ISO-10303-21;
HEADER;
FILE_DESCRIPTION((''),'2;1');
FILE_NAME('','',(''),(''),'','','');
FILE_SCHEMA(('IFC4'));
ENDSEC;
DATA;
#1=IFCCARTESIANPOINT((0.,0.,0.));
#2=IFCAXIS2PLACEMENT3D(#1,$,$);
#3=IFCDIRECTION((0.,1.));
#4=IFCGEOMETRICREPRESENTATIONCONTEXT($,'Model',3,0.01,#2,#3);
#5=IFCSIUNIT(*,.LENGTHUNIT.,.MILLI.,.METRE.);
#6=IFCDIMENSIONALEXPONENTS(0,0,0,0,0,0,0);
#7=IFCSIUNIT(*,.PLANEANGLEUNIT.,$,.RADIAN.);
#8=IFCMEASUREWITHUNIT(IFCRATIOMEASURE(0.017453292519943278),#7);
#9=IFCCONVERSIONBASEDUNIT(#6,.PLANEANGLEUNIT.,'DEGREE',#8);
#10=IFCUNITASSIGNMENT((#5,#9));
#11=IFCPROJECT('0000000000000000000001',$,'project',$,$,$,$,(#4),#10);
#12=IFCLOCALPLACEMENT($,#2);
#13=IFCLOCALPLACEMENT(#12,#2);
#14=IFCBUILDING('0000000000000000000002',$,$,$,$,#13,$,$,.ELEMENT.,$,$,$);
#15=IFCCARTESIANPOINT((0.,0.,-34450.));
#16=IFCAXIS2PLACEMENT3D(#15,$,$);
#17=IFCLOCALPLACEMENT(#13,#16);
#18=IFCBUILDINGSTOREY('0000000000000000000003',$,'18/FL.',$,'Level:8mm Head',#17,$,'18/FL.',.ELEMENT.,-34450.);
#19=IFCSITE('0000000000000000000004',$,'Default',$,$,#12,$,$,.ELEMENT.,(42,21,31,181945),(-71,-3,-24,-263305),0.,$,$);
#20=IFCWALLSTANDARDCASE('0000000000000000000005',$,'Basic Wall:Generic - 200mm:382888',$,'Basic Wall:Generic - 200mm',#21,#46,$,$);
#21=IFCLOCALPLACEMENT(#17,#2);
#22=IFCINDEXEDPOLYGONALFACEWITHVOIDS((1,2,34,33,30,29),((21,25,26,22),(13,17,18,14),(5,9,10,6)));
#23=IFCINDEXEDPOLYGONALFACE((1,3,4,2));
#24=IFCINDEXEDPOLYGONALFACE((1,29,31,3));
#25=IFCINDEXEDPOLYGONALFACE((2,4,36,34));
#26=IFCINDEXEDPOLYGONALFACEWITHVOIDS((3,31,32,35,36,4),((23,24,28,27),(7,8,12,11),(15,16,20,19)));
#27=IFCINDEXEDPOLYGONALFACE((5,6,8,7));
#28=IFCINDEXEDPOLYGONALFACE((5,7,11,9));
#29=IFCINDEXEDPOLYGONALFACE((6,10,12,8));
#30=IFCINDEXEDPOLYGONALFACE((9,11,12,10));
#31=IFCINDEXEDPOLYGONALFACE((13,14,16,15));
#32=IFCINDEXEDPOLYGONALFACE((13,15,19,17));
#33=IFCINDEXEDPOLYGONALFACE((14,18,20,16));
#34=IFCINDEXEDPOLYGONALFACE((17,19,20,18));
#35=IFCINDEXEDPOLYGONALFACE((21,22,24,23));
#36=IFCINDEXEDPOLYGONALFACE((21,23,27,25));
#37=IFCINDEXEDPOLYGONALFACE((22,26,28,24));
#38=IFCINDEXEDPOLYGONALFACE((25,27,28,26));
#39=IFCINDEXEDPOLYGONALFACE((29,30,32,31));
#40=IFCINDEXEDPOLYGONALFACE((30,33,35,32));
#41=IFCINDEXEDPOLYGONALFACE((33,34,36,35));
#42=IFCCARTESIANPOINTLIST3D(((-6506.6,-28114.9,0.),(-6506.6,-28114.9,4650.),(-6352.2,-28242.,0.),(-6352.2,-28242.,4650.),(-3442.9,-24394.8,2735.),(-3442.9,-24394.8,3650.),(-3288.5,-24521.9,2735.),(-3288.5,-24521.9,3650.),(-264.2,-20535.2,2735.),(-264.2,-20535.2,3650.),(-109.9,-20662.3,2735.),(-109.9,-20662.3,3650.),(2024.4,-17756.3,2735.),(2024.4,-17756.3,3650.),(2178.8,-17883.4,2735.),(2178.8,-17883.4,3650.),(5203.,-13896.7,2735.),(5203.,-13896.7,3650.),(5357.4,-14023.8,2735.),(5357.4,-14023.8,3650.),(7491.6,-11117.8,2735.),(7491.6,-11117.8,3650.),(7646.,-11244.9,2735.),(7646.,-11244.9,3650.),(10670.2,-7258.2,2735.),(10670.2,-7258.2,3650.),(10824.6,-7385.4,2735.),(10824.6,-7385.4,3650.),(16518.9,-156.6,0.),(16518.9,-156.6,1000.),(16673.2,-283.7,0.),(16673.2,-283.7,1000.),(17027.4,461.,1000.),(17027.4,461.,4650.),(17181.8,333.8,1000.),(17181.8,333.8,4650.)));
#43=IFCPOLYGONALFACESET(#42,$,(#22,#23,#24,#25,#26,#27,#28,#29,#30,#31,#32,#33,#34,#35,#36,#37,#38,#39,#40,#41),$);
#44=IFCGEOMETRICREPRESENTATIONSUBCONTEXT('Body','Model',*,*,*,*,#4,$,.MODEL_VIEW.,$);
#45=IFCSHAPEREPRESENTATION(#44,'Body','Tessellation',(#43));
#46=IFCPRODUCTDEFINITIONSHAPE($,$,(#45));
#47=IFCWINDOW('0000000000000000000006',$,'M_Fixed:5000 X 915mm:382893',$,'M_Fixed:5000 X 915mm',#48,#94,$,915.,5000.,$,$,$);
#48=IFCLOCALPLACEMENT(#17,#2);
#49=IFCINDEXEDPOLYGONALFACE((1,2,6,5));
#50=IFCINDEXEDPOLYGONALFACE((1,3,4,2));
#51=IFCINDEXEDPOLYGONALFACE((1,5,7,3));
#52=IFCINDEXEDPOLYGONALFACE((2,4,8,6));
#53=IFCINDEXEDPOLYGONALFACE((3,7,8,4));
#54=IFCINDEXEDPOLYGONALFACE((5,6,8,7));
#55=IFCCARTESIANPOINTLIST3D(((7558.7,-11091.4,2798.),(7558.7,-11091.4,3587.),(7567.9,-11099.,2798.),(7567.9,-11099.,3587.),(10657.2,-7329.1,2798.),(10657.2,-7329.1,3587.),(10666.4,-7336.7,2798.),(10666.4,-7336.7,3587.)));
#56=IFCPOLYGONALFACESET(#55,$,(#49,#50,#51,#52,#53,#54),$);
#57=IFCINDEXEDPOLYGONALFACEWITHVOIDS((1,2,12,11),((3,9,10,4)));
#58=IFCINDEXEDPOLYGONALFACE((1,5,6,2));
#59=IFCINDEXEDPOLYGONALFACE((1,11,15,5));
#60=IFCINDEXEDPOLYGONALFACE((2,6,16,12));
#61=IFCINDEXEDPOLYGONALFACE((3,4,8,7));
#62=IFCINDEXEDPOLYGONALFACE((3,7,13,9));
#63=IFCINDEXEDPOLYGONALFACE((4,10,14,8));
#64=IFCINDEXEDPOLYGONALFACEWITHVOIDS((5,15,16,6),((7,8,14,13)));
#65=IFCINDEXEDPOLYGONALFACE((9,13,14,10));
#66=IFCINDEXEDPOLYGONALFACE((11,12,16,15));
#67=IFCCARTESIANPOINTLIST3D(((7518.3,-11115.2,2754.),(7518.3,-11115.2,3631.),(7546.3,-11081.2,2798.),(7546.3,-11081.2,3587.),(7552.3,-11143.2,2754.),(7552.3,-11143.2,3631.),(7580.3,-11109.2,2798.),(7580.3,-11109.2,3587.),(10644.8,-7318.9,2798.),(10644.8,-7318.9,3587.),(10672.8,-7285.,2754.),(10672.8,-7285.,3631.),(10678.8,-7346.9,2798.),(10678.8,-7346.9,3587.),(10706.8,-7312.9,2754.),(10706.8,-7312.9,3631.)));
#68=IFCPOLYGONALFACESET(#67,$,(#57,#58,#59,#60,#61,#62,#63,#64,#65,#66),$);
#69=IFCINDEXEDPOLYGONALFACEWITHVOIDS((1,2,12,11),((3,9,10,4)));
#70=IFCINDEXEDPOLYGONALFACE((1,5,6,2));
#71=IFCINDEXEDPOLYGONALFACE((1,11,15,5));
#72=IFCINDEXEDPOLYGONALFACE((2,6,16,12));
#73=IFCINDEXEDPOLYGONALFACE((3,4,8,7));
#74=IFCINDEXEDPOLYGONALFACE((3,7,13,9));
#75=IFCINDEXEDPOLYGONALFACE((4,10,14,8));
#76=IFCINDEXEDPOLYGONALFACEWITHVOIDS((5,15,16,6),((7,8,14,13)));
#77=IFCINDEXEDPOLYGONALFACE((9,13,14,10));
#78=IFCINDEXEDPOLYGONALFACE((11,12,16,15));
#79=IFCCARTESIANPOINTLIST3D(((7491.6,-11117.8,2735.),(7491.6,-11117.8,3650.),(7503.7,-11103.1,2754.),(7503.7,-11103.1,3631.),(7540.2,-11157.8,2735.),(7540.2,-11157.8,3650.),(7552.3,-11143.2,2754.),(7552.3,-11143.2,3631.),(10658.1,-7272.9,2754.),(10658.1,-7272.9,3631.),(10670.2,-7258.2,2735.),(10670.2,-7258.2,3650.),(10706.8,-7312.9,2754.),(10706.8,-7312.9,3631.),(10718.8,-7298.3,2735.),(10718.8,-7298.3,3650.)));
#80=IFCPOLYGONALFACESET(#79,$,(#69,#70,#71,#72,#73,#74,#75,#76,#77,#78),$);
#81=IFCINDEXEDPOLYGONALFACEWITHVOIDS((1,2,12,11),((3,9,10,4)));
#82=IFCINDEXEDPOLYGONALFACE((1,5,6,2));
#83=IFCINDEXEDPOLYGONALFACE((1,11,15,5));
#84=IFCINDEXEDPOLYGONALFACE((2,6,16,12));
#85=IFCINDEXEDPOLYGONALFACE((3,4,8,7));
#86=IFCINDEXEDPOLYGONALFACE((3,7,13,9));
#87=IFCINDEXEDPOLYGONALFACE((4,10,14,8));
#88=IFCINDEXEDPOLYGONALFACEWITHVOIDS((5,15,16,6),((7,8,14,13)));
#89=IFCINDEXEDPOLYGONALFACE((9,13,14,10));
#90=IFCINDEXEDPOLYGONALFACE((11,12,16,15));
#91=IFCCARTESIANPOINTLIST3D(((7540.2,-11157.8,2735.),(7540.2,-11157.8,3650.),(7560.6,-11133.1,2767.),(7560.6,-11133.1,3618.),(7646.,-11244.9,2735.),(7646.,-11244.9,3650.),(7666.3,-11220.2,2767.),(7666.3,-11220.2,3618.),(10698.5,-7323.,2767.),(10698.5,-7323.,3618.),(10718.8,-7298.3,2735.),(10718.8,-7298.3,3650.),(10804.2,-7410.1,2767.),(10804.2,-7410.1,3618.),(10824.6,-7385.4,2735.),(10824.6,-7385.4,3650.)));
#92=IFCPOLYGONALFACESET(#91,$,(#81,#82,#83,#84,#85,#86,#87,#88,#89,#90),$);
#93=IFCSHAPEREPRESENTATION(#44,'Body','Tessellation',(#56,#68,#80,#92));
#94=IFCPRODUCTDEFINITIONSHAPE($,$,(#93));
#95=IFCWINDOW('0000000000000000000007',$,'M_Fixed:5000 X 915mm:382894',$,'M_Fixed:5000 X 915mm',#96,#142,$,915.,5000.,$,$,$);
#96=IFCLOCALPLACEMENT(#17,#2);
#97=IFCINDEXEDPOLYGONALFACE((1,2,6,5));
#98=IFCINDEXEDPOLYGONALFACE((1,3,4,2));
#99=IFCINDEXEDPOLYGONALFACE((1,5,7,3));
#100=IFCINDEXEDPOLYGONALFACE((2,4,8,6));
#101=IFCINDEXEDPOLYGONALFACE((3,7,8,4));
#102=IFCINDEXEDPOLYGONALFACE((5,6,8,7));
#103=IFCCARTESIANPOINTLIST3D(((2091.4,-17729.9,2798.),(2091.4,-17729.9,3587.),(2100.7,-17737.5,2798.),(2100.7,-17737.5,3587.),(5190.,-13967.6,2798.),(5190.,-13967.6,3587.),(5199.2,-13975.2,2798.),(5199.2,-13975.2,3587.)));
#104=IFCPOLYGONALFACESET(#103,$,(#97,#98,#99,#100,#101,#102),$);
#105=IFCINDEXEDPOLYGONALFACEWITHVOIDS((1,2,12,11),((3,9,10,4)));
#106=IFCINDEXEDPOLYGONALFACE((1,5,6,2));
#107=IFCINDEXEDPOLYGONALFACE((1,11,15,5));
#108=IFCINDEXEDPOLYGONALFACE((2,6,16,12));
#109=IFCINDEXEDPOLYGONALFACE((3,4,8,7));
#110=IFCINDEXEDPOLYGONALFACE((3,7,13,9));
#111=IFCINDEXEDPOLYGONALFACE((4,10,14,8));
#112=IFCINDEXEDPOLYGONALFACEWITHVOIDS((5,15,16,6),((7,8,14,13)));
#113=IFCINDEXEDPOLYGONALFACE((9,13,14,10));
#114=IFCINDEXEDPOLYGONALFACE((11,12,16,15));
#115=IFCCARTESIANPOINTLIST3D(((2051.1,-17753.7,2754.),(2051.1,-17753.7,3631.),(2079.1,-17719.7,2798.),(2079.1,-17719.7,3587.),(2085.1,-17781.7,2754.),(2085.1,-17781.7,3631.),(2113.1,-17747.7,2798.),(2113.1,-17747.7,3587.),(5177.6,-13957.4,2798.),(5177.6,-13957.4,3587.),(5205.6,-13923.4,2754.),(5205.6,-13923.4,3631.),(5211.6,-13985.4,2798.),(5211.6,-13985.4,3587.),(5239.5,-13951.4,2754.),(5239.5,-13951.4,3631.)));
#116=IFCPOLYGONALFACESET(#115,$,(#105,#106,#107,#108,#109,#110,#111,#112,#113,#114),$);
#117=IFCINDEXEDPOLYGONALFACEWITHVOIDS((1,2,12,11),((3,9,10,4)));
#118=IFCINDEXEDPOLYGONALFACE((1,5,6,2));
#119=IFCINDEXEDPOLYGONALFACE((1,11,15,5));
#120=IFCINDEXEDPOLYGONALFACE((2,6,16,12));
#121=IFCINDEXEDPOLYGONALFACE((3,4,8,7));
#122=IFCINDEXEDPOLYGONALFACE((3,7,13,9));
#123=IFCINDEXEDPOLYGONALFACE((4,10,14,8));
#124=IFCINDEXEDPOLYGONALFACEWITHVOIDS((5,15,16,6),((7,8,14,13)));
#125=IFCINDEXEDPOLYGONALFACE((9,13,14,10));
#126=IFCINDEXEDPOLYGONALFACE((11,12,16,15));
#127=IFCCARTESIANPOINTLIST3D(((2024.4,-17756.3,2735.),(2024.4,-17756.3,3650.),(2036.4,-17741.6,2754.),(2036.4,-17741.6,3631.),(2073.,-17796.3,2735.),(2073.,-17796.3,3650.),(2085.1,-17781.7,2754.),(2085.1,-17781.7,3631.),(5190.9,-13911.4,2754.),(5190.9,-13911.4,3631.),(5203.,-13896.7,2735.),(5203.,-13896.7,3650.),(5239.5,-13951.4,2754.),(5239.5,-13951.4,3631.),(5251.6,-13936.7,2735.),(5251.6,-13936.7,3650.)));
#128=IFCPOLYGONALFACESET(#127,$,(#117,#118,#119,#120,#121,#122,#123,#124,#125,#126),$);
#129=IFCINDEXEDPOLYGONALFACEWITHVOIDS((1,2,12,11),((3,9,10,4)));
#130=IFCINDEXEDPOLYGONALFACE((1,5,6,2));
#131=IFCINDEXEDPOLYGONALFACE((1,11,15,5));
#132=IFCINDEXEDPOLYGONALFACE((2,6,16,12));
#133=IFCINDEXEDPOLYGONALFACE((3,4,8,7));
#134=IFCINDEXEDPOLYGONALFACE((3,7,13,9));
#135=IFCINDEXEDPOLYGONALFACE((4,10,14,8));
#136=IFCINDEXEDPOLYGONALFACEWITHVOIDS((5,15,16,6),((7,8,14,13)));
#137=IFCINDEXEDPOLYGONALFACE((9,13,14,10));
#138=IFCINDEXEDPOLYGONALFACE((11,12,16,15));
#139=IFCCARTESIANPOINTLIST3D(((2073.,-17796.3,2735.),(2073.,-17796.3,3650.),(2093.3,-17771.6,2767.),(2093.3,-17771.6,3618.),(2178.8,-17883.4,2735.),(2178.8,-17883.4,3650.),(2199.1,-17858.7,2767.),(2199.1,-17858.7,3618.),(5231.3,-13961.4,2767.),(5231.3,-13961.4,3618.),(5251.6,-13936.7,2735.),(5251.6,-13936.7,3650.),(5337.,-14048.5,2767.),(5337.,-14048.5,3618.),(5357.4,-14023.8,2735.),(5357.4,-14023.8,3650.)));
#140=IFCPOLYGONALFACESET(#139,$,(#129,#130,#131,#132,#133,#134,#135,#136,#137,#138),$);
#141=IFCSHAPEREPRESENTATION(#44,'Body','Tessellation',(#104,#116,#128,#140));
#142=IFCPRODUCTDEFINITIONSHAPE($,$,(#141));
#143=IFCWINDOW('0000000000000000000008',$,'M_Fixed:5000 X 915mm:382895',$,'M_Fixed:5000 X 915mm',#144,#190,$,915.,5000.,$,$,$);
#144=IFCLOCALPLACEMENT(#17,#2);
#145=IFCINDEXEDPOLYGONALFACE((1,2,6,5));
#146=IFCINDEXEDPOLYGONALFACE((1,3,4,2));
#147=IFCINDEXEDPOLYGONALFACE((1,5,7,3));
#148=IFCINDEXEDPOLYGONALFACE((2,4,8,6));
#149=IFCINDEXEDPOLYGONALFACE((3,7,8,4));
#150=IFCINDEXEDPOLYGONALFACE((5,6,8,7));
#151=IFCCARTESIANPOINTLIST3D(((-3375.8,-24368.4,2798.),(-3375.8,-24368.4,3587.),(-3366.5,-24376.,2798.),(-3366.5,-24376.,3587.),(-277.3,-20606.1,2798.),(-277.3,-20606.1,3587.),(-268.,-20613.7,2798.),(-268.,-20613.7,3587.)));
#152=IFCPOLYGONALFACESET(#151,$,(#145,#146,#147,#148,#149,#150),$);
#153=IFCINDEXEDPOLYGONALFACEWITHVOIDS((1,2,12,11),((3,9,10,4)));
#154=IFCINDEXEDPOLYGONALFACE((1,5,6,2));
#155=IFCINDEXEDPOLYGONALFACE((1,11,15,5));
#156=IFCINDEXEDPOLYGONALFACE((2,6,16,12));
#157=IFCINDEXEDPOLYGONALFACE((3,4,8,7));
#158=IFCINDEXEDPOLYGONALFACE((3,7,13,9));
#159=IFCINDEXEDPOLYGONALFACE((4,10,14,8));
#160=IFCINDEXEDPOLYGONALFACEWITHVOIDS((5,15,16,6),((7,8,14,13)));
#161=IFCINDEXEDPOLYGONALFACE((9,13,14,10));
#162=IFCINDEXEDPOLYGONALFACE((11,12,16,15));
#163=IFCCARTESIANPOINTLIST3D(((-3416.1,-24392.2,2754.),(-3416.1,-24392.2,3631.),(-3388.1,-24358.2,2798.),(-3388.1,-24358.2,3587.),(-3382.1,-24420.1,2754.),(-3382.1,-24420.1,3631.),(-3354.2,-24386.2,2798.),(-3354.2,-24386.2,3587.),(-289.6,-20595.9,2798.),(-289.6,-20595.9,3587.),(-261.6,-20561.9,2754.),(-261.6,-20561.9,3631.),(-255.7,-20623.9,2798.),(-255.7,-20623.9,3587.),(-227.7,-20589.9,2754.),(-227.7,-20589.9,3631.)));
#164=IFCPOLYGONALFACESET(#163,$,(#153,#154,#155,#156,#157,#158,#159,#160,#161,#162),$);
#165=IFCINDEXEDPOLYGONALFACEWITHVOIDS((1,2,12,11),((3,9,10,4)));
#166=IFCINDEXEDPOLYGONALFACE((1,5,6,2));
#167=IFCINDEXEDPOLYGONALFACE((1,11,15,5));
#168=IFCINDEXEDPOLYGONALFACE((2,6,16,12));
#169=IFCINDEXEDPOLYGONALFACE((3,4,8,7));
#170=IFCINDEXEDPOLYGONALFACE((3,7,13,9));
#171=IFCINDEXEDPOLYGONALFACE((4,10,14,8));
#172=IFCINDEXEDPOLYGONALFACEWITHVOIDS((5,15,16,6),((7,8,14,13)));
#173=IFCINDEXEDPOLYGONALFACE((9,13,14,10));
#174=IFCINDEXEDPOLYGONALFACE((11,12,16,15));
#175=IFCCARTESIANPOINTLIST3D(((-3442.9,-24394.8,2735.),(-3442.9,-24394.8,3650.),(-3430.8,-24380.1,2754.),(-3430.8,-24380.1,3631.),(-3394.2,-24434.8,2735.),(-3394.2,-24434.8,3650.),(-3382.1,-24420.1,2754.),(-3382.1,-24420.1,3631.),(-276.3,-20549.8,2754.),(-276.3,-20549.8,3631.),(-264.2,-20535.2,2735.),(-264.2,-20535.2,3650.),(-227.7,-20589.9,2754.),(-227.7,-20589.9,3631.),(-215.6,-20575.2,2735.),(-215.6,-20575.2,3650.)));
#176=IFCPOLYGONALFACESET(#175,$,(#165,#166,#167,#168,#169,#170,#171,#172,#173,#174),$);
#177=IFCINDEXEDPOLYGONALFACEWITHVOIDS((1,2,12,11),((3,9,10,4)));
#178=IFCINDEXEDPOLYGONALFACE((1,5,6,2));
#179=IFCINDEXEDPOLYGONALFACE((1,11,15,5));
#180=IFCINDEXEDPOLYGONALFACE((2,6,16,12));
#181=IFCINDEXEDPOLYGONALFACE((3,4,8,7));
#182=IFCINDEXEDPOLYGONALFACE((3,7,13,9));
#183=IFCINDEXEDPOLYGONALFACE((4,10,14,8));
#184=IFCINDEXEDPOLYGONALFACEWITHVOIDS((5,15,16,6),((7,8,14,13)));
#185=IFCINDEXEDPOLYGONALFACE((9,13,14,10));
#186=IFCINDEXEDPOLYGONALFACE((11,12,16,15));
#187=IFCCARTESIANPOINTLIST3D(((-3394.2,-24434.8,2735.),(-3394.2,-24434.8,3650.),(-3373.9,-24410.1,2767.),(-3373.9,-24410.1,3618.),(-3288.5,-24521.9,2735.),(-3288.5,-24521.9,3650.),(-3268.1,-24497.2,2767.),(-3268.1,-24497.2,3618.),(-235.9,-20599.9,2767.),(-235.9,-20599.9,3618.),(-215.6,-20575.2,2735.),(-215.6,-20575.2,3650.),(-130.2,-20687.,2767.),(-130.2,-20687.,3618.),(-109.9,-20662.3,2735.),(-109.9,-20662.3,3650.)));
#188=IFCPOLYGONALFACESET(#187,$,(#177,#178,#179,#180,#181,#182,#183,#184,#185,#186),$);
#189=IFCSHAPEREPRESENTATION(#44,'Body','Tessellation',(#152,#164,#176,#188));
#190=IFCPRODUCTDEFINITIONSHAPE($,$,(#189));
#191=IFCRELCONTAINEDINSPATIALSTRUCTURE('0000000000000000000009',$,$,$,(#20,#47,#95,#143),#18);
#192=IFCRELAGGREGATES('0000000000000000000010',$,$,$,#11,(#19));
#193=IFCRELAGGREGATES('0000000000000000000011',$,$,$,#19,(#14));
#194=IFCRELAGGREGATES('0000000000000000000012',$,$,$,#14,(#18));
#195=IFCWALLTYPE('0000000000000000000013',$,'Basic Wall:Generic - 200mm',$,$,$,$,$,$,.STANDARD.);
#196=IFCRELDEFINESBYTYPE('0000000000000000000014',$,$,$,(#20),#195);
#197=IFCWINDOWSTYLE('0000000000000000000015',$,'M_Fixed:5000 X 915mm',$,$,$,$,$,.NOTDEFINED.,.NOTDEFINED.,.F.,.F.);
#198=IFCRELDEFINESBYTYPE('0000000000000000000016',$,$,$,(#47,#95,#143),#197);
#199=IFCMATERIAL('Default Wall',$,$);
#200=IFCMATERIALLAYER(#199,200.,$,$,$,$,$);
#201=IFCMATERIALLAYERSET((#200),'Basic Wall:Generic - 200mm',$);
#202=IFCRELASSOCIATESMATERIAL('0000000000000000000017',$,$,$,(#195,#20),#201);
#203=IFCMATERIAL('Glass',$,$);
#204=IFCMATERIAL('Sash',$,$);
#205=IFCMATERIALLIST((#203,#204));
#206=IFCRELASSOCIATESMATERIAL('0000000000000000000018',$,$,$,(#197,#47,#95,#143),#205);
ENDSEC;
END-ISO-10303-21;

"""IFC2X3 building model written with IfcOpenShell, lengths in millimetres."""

from ifc_helpers import new_model, entity, si_unit, converted_unit, direction, frame, frame_2d, origin, place, context, subcontext, project, spatial, polyline, rectangle, outline, extrude, source, transform, mapped, material, material_list, layer, layer_set, layer_usage, type_object, type_shapes, element, fill, save


model = new_model("IFC2X3")

# Units and contexts
model_context = context("Model", 3, precision=0.01, world=origin(), true_north=direction((0.0, 1.0)))
body_context = subcontext(model_context, "Body", "Model", "MODEL_VIEW")
ifc_project = project(units=[si_unit("LENGTHUNIT", "METRE", prefix="MILLI"), converted_unit("PLANEANGLEUNIT", "DEGREE", entity("IfcRatioMeasure", 0.017453292519943278), si_unit("PLANEANGLEUNIT", "RADIAN"), dimensions=[0, 0, 0, 0, 0, 0, 0])], contexts=[model_context])

# Site, building, storey
site_placement = place(None, origin())
site = spatial("IfcSite", under=ifc_project, at=site_placement, Name="Default", CompositionType="ELEMENT", RefLatitude=(42, 21, 31, 181945), RefLongitude=(-71, -3, -24, -263305), RefElevation=0.0)
building_placement = place(site_placement, origin())
building = spatial("IfcBuilding", under=site, at=building_placement, CompositionType="ELEMENT")
storey_placement = place(building_placement, frame((0.0, 0.0, -34450.0)))
storey = spatial("IfcBuildingStorey", under=building, at=storey_placement, Name="18/FL.", ObjectType="Level:8mm Head", LongName="18/FL.", CompositionType="ELEMENT", Elevation=-34450.0)

# Shared definitions
ifc_material_1 = material(Name="Default Wall")
ifc_layer = layer(ifc_material_1, 200.0)
ifc_layer_set = layer_set([ifc_layer], Name="Basic Wall:Generic - 200mm")
ifc_layer_usage = layer_usage(ifc_layer_set, "AXIS2", "NEGATIVE", 100.0)
wall_type = type_object("IfcWallType", Name="Basic Wall:Generic - 200mm", PredefinedType="STANDARD", material=ifc_layer_set)

# Wall, openings, windows
wall_1_placement = place(storey_placement, frame((17104.6, 397.4, 0.0), z_axis=(0.0, 0.0, 1.0), x_axis=(-0.635723, -0.771917, 0.0)))
wall_1 = element("IfcWallStandardCase", 1, at=wall_1_placement, inside=storey, type_object=wall_type, material=ifc_layer_usage, Name="Basic Wall:Generic - 200mm:382888", ObjectType="Basic Wall:Generic - 200mm", context=body_context, shape_type="SweptSolid", body=[
    extrude(rectangle(XDim=37019.3, YDim=200.0, at=frame_2d((18509.7, 0.0), x_axis=(-1.0, 0.0))), origin(), (0.0, 0.0, 1.0), 4650.0),
])
opening_1_placement = place(wall_1_placement, origin())
element("IfcOpeningElement", 2, at=opening_1_placement, cuts=wall_1, ObjectType="Opening", context=body_context, shape_type="SweptSolid", body=[
    extrude(rectangle(XDim=1000.0, YDim=1012.7, at=frame_2d((0.0, 0.0), x_axis=(1.0, 0.0))), frame((293.7, -183.3, 500.0), z_axis=(0.0, 1.0, 0.0), x_axis=(0.0, 0.0, -1.0)), (0.0, 0.0, 1.0), 1010.1),
])
opening_2_placement = place(wall_1_placement, frame((15000.0, 100.0, 2735.0)))
opening_2 = element("IfcOpeningElement", 3, at=opening_2_placement, cuts=wall_1, ObjectType="Opening", context=body_context, shape_type="SweptSolid", body=[
    extrude(rectangle(XDim=915.0, YDim=5000.0, at=frame_2d((457.5, 2500.0), x_axis=(1.0, 0.0))), frame((0.0, 0.0, 0.0), z_axis=(0.0, -1.0, 0.0), x_axis=(0.0, 0.0, 1.0)), (0.0, 0.0, 1.0), 200.0),
])
opening_3_placement = place(wall_1_placement, frame((23600.0, 100.0, 2735.0)))
opening_3 = element("IfcOpeningElement", 4, at=opening_3_placement, cuts=wall_1, ObjectType="Opening", context=body_context, shape_type="SweptSolid", body=[
    extrude(rectangle(XDim=915.0, YDim=5000.0, at=frame_2d((457.5, 2500.0), x_axis=(1.0, 0.0))), frame((0.0, 0.0, 0.0), z_axis=(0.0, -1.0, 0.0), x_axis=(0.0, 0.0, 1.0)), (0.0, 0.0, 1.0), 200.0),
])
opening_4_placement = place(wall_1_placement, frame((32200.0, 100.0, 2735.0)))
opening_4 = element("IfcOpeningElement", 5, at=opening_4_placement, cuts=wall_1, ObjectType="Opening", context=body_context, shape_type="SweptSolid", body=[
    extrude(rectangle(XDim=915.0, YDim=5000.0, at=frame_2d((457.5, 2500.0), x_axis=(1.0, 0.0))), frame((0.0, 0.0, 0.0), z_axis=(0.0, -1.0, 0.0), x_axis=(0.0, 0.0, 1.0)), (0.0, 0.0, 1.0), 200.0),
])
ifc_material_2 = material(Name="Glass")
ifc_material_3 = material(Name="Sash")
ifc_material_list = material_list([ifc_material_2, ifc_material_3])
window_style_1 = type_object("IfcWindowStyle", Name="M_Fixed:5000 X 915mm", ConstructionType="NOTDEFINED", OperationType="NOTDEFINED", ParameterTakesPrecedence=False, Sizeable=False, material=ifc_material_list)
shared_shape_1 = source(origin(), body_context, "Body", "SweptSolid", [
    extrude(rectangle(XDim=12.0, YDim=4874.0, at=frame_2d((0.0, 0.0), x_axis=(1.0, 0.0))), frame((2500.0, 159.0, 63.0), z_axis=(0.0, 0.0, 1.0), x_axis=(0.0, -1.0, 0.0)), (0.0, 0.0, 1.0), 789.0),
    extrude(outline(polyline([(-2481.0, -438.5), (2481.0, -438.5), (2481.0, 438.5), (-2481.0, 438.5), (-2481.0, -438.5)]), holes=[polyline([(-2437.0, -394.5), (-2437.0, 394.5), (2437.0, 394.5), (2437.0, -394.5), (-2437.0, -394.5)])]), frame((2500.0, 137.0, 457.5), z_axis=(0.0, 1.0, 0.0), x_axis=(1.0, 0.0, 0.0)), (0.0, 0.0, 1.0), 44.0),
    extrude(outline(polyline([(-2500.0, -457.5), (2500.0, -457.5), (2500.0, 457.5), (-2500.0, 457.5), (-2500.0, -457.5)]), holes=[polyline([(-2481.0, -438.5), (-2481.0, 438.5), (2481.0, 438.5), (2481.0, -438.5), (-2481.0, -438.5)])]), frame((2500.0, 137.0, 457.5), z_axis=(0.0, 1.0, 0.0), x_axis=(1.0, 0.0, 0.0)), (0.0, 0.0, 1.0), 63.0),
    extrude(outline(polyline([(-2500.0, -457.5), (2500.0, -457.5), (2500.0, 457.5), (-2500.0, 457.5), (-2500.0, -457.5)]), holes=[polyline([(-2468.0, -425.5), (-2468.0, 425.5), (2468.0, 425.5), (2468.0, -425.5), (-2468.0, -425.5)])]), frame((2500.0, 0.0, 457.5), z_axis=(0.0, 1.0, 0.0), x_axis=(1.0, 0.0, 0.0)), (0.0, 0.0, 1.0), 137.0),
])
type_shapes(window_style_1, [shared_shape_1])
window_1_placement = place(opening_2_placement, frame((0.0, 0.0, 0.0), z_axis=(0.0, 0.0, 1.0), x_axis=(-1.0, 0.0, 0.0)))
window_1 = element("IfcWindow", 6, at=window_1_placement, inside=storey, type_object=window_style_1, material=ifc_material_list, Name="M_Fixed:5000 X 915mm:382893", ObjectType="M_Fixed:5000 X 915mm", OverallHeight=915.0, OverallWidth=5000.0, context=body_context, shape_type="MappedRepresentation", body=[
    mapped(shared_shape_1, transform((0.0, 0.0, 0.0), scale=1.0)),
])
fill(opening_2, window_1)
window_2_placement = place(opening_3_placement, frame((0.0, 0.0, 0.0), z_axis=(0.0, 0.0, 1.0), x_axis=(-1.0, 0.0, 0.0)))
window_2 = element("IfcWindow", 7, at=window_2_placement, inside=storey, type_object=window_style_1, material=ifc_material_list, Name="M_Fixed:5000 X 915mm:382894", ObjectType="M_Fixed:5000 X 915mm", OverallHeight=915.0, OverallWidth=5000.0, context=body_context, shape_type="MappedRepresentation", body=[
    mapped(shared_shape_1, transform((0.0, 0.0, 0.0), scale=1.0)),
])
fill(opening_3, window_2)
window_3_placement = place(opening_4_placement, frame((0.0, 0.0, 0.0), z_axis=(0.0, 0.0, 1.0), x_axis=(-1.0, 0.0, 0.0)))
window_3 = element("IfcWindow", 8, at=window_3_placement, inside=storey, type_object=window_style_1, material=ifc_material_list, Name="M_Fixed:5000 X 915mm:382895", ObjectType="M_Fixed:5000 X 915mm", OverallHeight=915.0, OverallWidth=5000.0, context=body_context, shape_type="MappedRepresentation", body=[
    mapped(shared_shape_1, transform((0.0, 0.0, 0.0), scale=1.0)),
])
fill(opening_4, window_3)

save(model, "model.ifc")
